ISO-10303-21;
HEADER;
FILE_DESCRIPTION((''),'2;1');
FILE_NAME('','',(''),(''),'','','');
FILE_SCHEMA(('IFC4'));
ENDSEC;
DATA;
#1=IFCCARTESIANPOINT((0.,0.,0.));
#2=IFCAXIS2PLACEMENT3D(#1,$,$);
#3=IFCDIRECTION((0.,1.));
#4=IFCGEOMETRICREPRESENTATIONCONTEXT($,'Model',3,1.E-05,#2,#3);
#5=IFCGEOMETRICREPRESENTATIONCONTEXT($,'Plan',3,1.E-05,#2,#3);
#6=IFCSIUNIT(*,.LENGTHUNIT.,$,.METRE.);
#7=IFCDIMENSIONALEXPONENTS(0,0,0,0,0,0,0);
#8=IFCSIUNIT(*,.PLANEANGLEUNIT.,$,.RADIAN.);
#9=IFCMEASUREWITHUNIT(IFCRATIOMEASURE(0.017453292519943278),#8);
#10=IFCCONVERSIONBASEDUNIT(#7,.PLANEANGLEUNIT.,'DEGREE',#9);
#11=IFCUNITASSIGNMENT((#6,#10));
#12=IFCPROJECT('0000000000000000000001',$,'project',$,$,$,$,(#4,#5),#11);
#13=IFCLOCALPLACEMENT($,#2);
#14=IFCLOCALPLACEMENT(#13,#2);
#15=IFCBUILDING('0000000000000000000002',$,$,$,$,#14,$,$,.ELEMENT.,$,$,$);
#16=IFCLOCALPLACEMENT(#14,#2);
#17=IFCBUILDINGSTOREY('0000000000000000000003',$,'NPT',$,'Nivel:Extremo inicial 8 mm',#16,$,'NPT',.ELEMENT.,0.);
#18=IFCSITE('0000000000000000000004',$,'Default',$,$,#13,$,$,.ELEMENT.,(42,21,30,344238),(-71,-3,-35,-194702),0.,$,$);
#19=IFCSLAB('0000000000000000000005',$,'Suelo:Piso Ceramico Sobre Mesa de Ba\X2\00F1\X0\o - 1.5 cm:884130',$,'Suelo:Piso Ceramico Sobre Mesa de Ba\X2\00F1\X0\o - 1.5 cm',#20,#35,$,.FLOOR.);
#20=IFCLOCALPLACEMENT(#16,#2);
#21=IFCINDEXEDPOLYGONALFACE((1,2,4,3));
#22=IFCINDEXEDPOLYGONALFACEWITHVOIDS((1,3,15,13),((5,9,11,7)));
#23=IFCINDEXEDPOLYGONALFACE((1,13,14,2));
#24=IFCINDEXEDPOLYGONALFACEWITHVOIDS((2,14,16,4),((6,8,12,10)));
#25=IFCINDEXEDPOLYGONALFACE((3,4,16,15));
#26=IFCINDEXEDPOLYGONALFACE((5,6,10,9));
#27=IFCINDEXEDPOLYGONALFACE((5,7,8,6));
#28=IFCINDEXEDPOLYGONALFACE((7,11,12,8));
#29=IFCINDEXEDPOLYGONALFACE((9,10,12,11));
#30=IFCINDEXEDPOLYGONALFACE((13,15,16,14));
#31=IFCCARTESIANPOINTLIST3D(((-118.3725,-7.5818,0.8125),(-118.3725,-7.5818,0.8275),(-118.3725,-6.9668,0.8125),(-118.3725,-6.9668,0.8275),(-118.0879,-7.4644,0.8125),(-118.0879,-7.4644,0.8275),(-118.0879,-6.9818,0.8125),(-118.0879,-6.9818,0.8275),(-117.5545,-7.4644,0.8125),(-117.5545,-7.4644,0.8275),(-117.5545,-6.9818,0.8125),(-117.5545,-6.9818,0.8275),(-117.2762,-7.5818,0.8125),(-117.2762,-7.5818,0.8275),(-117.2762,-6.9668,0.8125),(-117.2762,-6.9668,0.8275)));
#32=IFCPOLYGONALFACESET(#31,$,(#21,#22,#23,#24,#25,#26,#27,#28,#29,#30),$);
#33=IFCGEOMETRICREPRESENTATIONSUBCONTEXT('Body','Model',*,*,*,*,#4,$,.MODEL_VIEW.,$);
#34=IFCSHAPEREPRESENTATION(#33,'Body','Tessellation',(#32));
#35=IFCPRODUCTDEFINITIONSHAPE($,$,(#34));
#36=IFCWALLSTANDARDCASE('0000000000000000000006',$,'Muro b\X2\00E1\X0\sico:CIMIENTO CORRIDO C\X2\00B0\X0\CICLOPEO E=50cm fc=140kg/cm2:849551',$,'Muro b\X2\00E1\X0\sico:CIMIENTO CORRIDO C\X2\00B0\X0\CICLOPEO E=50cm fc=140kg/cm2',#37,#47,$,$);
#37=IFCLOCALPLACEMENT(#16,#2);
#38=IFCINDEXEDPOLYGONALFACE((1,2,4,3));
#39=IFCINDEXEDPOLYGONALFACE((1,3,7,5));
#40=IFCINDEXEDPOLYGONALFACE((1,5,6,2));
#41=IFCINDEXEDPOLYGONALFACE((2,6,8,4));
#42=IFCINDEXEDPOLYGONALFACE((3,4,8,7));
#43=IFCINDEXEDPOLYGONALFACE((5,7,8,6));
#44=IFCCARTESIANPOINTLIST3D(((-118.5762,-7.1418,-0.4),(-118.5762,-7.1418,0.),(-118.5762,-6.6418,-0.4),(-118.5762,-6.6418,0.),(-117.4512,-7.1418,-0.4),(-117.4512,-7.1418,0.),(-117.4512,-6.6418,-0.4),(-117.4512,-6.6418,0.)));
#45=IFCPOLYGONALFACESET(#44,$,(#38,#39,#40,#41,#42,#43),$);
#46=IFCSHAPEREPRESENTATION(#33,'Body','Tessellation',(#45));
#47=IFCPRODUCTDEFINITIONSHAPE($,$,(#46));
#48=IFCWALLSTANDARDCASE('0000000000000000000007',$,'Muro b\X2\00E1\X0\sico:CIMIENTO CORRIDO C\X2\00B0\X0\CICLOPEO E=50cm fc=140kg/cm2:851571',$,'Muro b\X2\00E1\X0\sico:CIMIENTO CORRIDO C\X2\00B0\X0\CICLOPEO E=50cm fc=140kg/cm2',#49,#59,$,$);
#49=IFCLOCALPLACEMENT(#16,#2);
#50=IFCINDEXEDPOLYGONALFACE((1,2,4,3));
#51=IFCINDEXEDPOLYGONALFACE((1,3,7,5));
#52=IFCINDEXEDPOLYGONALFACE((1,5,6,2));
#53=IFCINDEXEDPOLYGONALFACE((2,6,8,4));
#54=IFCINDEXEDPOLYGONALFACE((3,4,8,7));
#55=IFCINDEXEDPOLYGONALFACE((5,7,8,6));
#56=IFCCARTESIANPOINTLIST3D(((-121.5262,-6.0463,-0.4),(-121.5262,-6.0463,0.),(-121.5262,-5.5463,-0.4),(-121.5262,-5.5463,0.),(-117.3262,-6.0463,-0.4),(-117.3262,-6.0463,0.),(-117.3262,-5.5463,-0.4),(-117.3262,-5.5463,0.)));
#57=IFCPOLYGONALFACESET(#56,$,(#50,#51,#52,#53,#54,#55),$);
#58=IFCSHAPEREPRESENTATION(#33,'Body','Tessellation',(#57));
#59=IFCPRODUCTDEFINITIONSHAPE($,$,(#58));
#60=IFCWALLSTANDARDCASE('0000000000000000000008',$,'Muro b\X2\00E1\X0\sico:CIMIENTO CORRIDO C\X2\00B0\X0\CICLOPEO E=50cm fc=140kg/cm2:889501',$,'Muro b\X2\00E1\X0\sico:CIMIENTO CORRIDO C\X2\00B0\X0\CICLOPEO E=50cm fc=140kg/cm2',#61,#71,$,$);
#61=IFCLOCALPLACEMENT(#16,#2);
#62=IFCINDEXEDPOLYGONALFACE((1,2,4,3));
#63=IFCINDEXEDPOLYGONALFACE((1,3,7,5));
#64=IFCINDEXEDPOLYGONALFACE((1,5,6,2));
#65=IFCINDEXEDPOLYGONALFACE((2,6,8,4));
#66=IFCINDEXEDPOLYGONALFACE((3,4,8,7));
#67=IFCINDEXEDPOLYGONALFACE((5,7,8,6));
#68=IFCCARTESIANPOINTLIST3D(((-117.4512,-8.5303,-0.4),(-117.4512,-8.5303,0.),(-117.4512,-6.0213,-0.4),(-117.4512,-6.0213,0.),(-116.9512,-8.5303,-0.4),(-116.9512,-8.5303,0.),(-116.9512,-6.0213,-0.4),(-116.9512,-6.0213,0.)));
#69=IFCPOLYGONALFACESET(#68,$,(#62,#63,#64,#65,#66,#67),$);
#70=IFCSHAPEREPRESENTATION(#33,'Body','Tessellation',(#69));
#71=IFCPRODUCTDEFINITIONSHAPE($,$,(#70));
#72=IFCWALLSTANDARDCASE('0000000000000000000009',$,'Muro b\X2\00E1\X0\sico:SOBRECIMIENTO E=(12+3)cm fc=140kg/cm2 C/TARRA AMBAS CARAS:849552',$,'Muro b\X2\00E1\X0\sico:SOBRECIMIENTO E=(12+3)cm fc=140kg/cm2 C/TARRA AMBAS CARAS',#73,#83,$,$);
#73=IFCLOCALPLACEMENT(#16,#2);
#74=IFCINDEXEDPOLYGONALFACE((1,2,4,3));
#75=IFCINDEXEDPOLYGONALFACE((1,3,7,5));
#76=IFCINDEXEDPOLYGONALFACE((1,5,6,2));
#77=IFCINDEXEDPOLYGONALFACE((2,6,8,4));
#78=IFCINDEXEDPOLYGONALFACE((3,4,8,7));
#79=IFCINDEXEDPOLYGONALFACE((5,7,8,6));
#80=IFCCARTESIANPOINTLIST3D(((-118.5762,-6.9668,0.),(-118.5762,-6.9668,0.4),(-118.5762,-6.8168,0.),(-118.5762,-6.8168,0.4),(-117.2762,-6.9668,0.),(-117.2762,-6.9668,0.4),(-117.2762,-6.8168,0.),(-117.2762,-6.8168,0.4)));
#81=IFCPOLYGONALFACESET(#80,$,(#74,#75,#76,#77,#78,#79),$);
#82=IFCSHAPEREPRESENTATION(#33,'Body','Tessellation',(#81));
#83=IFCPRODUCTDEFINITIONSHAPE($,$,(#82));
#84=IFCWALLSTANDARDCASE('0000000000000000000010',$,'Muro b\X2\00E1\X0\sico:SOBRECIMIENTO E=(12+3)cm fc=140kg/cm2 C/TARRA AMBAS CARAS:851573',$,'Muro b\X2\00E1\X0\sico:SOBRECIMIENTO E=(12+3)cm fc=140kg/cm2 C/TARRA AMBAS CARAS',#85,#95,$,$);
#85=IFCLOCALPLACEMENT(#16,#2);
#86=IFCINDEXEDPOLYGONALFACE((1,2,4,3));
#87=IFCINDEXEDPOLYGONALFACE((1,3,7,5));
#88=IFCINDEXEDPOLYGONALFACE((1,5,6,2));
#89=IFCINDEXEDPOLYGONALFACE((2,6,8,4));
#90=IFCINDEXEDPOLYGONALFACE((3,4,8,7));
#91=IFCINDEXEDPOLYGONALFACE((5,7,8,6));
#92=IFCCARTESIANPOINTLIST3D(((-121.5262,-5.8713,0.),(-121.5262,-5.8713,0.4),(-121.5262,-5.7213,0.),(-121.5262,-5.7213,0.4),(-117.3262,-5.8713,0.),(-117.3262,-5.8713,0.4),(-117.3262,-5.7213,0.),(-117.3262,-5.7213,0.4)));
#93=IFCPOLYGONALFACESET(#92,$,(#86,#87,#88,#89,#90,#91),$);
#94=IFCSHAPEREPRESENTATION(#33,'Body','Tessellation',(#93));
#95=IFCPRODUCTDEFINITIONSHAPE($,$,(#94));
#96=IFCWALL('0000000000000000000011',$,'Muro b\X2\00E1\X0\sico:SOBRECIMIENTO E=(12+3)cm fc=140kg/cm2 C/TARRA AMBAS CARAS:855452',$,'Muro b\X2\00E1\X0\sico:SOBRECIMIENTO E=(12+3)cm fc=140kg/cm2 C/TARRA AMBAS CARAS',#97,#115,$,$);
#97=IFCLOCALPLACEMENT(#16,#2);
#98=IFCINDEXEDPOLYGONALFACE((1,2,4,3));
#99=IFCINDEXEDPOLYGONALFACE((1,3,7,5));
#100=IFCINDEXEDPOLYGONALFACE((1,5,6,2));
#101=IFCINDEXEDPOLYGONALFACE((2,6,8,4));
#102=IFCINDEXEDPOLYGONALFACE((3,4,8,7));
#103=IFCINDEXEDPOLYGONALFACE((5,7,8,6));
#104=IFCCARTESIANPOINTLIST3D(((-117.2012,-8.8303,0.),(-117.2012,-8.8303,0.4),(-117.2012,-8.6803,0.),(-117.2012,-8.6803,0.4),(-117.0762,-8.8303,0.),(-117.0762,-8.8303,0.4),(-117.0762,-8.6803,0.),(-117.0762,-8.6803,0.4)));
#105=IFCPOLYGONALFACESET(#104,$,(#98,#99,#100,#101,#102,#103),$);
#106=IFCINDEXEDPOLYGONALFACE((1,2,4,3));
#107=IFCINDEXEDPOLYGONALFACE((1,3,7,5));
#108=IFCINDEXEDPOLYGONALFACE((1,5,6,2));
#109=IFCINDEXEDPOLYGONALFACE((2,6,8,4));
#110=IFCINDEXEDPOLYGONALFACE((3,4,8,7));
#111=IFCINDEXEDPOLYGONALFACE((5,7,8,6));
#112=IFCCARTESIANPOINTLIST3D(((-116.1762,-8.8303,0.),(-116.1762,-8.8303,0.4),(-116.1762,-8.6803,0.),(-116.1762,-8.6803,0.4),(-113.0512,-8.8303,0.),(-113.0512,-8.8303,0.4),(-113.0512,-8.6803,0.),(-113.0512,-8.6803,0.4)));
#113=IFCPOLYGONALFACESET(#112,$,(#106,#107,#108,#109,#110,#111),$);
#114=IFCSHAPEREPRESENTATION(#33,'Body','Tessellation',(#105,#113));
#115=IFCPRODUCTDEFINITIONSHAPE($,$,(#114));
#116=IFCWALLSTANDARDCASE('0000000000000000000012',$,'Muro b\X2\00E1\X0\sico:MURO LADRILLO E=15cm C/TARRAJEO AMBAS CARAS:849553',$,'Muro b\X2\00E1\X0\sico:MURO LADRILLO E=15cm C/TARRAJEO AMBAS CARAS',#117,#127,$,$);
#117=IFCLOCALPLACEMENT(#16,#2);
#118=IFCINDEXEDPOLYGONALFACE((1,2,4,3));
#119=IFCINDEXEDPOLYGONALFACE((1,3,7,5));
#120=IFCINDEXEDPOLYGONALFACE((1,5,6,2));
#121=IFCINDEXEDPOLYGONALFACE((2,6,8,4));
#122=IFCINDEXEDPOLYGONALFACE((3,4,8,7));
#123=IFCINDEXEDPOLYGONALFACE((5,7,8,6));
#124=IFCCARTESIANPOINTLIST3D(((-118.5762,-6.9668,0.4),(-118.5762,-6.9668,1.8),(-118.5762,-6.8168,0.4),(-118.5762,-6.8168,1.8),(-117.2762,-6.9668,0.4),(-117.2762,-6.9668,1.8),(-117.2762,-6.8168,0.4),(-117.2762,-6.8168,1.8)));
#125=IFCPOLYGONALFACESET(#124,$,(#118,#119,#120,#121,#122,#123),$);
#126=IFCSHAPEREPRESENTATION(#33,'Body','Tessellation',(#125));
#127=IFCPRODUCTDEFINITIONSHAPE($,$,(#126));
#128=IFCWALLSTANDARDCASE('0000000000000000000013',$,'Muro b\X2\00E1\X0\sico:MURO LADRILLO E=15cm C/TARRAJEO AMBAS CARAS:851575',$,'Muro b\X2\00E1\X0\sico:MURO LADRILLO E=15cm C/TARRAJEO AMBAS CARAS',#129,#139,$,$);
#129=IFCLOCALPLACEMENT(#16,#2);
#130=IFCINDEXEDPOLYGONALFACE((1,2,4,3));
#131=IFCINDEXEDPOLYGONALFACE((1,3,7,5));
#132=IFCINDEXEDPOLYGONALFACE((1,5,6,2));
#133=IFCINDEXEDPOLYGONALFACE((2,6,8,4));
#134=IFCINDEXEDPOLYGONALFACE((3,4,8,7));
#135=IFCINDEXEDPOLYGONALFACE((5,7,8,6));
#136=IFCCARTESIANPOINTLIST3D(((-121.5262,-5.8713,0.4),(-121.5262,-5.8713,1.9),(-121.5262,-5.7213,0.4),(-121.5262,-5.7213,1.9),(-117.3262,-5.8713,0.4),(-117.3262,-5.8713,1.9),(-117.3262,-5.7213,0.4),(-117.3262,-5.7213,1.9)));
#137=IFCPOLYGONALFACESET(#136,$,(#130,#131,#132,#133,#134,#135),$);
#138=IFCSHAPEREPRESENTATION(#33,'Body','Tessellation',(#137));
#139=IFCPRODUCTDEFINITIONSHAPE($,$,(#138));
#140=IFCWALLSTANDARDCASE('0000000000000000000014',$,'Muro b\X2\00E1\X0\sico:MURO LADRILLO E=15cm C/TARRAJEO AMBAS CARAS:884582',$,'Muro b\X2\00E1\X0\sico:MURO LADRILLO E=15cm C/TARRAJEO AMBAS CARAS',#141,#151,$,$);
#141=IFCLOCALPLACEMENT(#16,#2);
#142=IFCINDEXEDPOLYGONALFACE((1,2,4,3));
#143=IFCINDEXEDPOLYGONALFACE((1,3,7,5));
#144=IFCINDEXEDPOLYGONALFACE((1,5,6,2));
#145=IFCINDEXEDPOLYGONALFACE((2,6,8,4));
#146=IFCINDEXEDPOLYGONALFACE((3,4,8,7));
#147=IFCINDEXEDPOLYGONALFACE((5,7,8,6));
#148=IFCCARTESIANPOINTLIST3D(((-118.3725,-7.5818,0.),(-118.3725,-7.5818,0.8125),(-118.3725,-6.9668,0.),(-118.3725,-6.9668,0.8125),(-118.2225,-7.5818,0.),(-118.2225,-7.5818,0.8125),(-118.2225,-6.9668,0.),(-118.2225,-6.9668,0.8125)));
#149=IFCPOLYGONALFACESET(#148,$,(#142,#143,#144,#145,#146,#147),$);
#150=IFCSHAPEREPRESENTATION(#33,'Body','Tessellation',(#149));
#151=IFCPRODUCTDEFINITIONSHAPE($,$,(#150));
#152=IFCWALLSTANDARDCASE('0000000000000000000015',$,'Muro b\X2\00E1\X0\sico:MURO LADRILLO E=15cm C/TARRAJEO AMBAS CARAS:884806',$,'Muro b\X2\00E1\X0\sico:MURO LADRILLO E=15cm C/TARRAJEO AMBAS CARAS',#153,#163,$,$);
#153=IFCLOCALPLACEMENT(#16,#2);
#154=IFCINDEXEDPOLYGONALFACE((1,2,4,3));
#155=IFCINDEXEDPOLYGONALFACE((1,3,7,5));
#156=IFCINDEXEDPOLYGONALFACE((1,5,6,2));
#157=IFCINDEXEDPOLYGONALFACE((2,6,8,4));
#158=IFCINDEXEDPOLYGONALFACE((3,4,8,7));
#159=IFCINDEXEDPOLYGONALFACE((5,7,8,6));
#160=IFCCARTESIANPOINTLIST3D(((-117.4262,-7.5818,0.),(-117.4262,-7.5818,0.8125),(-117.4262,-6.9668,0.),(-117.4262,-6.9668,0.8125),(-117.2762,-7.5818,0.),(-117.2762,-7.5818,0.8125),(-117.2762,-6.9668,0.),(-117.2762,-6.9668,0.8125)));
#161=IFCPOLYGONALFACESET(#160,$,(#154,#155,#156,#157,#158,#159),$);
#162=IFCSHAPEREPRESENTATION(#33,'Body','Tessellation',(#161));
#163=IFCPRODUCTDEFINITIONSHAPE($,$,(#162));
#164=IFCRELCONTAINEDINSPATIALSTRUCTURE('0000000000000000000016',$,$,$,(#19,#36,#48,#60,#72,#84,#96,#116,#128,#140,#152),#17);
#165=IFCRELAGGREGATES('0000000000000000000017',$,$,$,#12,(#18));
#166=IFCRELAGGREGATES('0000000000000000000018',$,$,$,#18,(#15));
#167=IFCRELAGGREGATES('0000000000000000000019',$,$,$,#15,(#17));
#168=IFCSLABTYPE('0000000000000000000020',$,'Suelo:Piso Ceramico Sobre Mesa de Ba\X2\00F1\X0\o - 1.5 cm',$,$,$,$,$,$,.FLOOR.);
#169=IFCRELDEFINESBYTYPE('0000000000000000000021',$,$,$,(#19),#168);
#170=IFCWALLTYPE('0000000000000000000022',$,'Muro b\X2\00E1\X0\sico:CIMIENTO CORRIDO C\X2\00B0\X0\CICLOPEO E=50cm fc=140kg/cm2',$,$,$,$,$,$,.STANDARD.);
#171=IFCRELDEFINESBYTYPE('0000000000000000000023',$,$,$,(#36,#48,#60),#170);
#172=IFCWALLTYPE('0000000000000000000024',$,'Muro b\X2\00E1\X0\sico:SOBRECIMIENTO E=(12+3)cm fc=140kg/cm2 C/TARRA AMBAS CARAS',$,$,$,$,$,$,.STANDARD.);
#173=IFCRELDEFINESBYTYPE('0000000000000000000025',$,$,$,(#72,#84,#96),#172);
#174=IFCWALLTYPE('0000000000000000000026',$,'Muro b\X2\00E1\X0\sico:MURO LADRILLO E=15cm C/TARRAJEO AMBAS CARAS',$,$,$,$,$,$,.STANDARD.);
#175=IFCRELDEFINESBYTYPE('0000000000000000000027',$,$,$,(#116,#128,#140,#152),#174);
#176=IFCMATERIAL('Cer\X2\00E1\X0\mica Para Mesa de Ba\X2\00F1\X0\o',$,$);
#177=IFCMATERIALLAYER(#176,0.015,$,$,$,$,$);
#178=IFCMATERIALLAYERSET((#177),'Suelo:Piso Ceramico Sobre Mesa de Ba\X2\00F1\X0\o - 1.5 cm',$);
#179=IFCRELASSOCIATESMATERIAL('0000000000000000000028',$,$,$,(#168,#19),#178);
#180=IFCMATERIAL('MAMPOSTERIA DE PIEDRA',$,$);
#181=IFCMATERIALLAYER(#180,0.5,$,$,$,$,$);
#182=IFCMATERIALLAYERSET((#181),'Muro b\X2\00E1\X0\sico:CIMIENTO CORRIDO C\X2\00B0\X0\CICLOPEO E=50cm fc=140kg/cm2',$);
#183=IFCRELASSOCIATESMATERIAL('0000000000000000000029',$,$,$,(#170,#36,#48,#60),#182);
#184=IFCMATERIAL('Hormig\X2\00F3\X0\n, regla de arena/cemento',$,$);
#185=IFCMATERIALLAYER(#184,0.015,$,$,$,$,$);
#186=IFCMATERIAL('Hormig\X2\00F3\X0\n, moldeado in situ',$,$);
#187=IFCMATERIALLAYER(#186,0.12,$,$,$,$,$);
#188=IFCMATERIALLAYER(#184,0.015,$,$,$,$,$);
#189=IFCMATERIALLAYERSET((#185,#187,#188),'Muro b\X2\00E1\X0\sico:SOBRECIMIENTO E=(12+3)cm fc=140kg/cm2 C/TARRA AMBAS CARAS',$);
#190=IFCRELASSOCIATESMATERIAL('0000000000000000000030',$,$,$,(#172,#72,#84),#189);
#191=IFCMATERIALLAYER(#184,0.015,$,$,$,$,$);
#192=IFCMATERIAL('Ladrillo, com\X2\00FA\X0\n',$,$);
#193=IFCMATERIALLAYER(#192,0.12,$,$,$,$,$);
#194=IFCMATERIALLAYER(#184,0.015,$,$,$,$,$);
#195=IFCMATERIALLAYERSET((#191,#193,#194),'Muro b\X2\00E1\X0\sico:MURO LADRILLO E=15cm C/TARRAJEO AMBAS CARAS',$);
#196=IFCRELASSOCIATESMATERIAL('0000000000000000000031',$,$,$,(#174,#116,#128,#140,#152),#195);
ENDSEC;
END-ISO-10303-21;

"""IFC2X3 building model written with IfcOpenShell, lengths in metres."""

from ifc_helpers import new_model, entity, si_unit, converted_unit, direction, frame, frame_2d, origin, origin_2d_with_axis, place, context, subcontext, project, spatial, rectangle, extrude, material, layer, layer_set, layer_usage, type_object, element, save


model = new_model("IFC2X3")

# Units and contexts
model_context = context("Model", 3, precision=1e-05, world=origin(), true_north=direction((0.0, 1.0)))
plan_context = context("Plan", 3, precision=1e-05, world=origin(), true_north=direction((0.0, 1.0)))
body_context = subcontext(model_context, "Body", "Model", "MODEL_VIEW")
ifc_project = project(units=[si_unit("LENGTHUNIT", "METRE"), converted_unit("PLANEANGLEUNIT", "DEGREE", entity("IfcRatioMeasure", 0.017453292519943278), si_unit("PLANEANGLEUNIT", "RADIAN"), dimensions=[0, 0, 0, 0, 0, 0, 0])], contexts=[model_context, plan_context])

# Site, building, storey
site_placement = place(None, origin())
site = spatial("IfcSite", under=ifc_project, at=site_placement, Name="Default", CompositionType="ELEMENT", RefLatitude=(42, 21, 30, 344238), RefLongitude=(-71, -3, -35, -194702), RefElevation=0.0)
building_placement = place(site_placement, origin())
building = spatial("IfcBuilding", under=site, at=building_placement, CompositionType="ELEMENT")
storey_placement = place(building_placement, origin())
storey = spatial("IfcBuildingStorey", under=building, at=storey_placement, Name="NPT", ObjectType="Nivel:Extremo inicial 8 mm", LongName="NPT", CompositionType="ELEMENT", Elevation=0.0)

# Slab, opening
ifc_material_1 = material(Name="Cerámica Para Mesa de Baño")
ifc_layer_1 = layer(ifc_material_1, 0.015)
ifc_layer_set_1 = layer_set([ifc_layer_1], Name="Suelo:Piso Ceramico Sobre Mesa de Baño - 1.5 cm")
ifc_layer_usage_1 = layer_usage(ifc_layer_set_1, "AXIS3", "POSITIVE", 0.0)
slab_type = type_object("IfcSlabType", Name="Suelo:Piso Ceramico Sobre Mesa de Baño - 1.5 cm", PredefinedType="FLOOR", material=ifc_layer_set_1)
slab_placement = place(storey_placement, frame((-118.3725, -7.5818, 0.8125)))
slab = element("IfcSlab", 1, at=slab_placement, inside=storey, type_object=slab_type, material=ifc_layer_usage_1, Name="Suelo:Piso Ceramico Sobre Mesa de Baño - 1.5 cm:884130", ObjectType="Suelo:Piso Ceramico Sobre Mesa de Baño - 1.5 cm", PredefinedType="FLOOR", context=body_context, shape_type="SweptSolid", body=[
    extrude(rectangle(XDim=0.615, YDim=1.0962, at=frame_2d((0.0, 0.0), x_axis=(0.0, 1.0))), frame((0.5481, 0.3075, 0.015), z_axis=(0.0, 0.0, -1.0), x_axis=(-1.0, 0.0, 0.0)), (0.0, 0.0, 1.0), 0.015),
])
opening_placement = place(slab_placement, frame((0.5513, 0.3587, 0.015)))
element("IfcOpeningElement", 2, at=opening_placement, cuts=slab, ObjectType="Opening", context=body_context, shape_type="SweptSolid", body=[
    extrude(rectangle(XDim=0.5334, YDim=0.4826, at=origin_2d_with_axis()), frame((0.0, 0.0, 0.0), z_axis=(0.0, 0.0, -1.0), x_axis=(-1.0, 0.0, 0.0)), (0.0, 0.0, 1.0), 0.015),
])

# Walls
ifc_material_2 = material(Name="MAMPOSTERIA DE PIEDRA")
ifc_layer_2 = layer(ifc_material_2, 0.5)
ifc_layer_set_2 = layer_set([ifc_layer_2], Name="Muro básico:CIMIENTO CORRIDO C°CICLOPEO E=50cm fc=140kg/cm2")
ifc_layer_usage_2 = layer_usage(ifc_layer_set_2, "AXIS2", "POSITIVE", -0.25)
wall_type_1 = type_object("IfcWallType", Name="Muro básico:CIMIENTO CORRIDO C°CICLOPEO E=50cm fc=140kg/cm2", PredefinedType="STANDARD", material=ifc_layer_set_2)
wall_1_placement = place(storey_placement, frame((-118.5762, -6.8918, -0.4)))
element("IfcWallStandardCase", 3, at=wall_1_placement, inside=storey, type_object=wall_type_1, material=ifc_layer_usage_2, Name="Muro básico:CIMIENTO CORRIDO C°CICLOPEO E=50cm fc=140kg/cm2:849551", ObjectType="Muro básico:CIMIENTO CORRIDO C°CICLOPEO E=50cm fc=140kg/cm2", context=body_context, shape_type="SweptSolid", body=[
    extrude(rectangle(XDim=1.125, YDim=0.5, at=frame_2d((0.5625, 0.0), x_axis=(-1.0, 0.0))), origin(), (0.0, 0.0, 1.0), 0.4),
])
ifc_layer_usage_3 = layer_usage(ifc_layer_set_2, "AXIS2", "POSITIVE", -0.25)
wall_2_placement = place(storey_placement, frame((-117.3262, -5.7963, -0.4), z_axis=(0.0, 0.0, 1.0), x_axis=(-1.0, 0.0, 0.0)))
element("IfcWallStandardCase", 4, at=wall_2_placement, inside=storey, type_object=wall_type_1, material=ifc_layer_usage_3, Name="Muro básico:CIMIENTO CORRIDO C°CICLOPEO E=50cm fc=140kg/cm2:851571", ObjectType="Muro básico:CIMIENTO CORRIDO C°CICLOPEO E=50cm fc=140kg/cm2", context=body_context, shape_type="SweptSolid", body=[
    extrude(rectangle(XDim=4.2, YDim=0.5, at=frame_2d((2.1, 0.0), x_axis=(-1.0, 0.0))), origin(), (0.0, 0.0, 1.0), 0.4),
])
ifc_layer_usage_4 = layer_usage(ifc_layer_set_2, "AXIS2", "NEGATIVE", 0.25)
wall_3_placement = place(storey_placement, frame((-117.2012, -8.5303, -0.4), z_axis=(0.0, 0.0, 1.0), x_axis=(0.0, 1.0, 0.0)))
element("IfcWallStandardCase", 5, at=wall_3_placement, inside=storey, type_object=wall_type_1, material=ifc_layer_usage_4, Name="Muro básico:CIMIENTO CORRIDO C°CICLOPEO E=50cm fc=140kg/cm2:889501", ObjectType="Muro básico:CIMIENTO CORRIDO C°CICLOPEO E=50cm fc=140kg/cm2", context=body_context, shape_type="SweptSolid", body=[
    extrude(rectangle(XDim=2.5091, YDim=0.5, at=frame_2d((1.2545, 0.0), x_axis=(-1.0, 0.0))), origin(), (0.0, 0.0, 1.0), 0.4),
])
ifc_material_3 = material(Name="Hormigón, regla de arena/cemento")
ifc_layer_3 = layer(ifc_material_3, 0.015)
ifc_material_4 = material(Name="Hormigón, moldeado in situ")
ifc_layer_4 = layer(ifc_material_4, 0.12)
ifc_layer_5 = layer(ifc_material_3, 0.015)
ifc_layer_set_3 = layer_set([ifc_layer_3, ifc_layer_4, ifc_layer_5], Name="Muro básico:SOBRECIMIENTO E=(12+3)cm fc=140kg/cm2 C/TARRA AMBAS CARAS")
ifc_layer_usage_5 = layer_usage(ifc_layer_set_3, "AXIS2", "POSITIVE", -0.075)
wall_type_2 = type_object("IfcWallType", Name="Muro básico:SOBRECIMIENTO E=(12+3)cm fc=140kg/cm2 C/TARRA AMBAS CARAS", PredefinedType="STANDARD", material=ifc_layer_set_3)
wall_4_placement = place(storey_placement, frame((-118.5762, -6.8918, 0.0)))
element("IfcWallStandardCase", 6, at=wall_4_placement, inside=storey, type_object=wall_type_2, material=ifc_layer_usage_5, Name="Muro básico:SOBRECIMIENTO E=(12+3)cm fc=140kg/cm2 C/TARRA AMBAS CARAS:849552", ObjectType="Muro básico:SOBRECIMIENTO E=(12+3)cm fc=140kg/cm2 C/TARRA AMBAS CARAS", context=body_context, shape_type="SweptSolid", body=[
    extrude(rectangle(XDim=1.3, YDim=0.15, at=frame_2d((0.65, 0.0), x_axis=(-1.0, 0.0))), origin(), (0.0, 0.0, 1.0), 0.4),
])
ifc_layer_usage_6 = layer_usage(ifc_layer_set_3, "AXIS2", "POSITIVE", -0.075)
wall_5_placement = place(storey_placement, frame((-117.3262, -5.7963, 0.0), z_axis=(0.0, 0.0, 1.0), x_axis=(-1.0, 0.0, 0.0)))
element("IfcWallStandardCase", 7, at=wall_5_placement, inside=storey, type_object=wall_type_2, material=ifc_layer_usage_6, Name="Muro básico:SOBRECIMIENTO E=(12+3)cm fc=140kg/cm2 C/TARRA AMBAS CARAS:851573", ObjectType="Muro básico:SOBRECIMIENTO E=(12+3)cm fc=140kg/cm2 C/TARRA AMBAS CARAS", context=body_context, shape_type="SweptSolid", body=[
    extrude(rectangle(XDim=4.2, YDim=0.15, at=frame_2d((2.1, 0.0), x_axis=(-1.0, 0.0))), origin(), (0.0, 0.0, 1.0), 0.4),
])
wall_6_placement = place(storey_placement, frame((-117.2012, -8.7553, 0.0)))
element("IfcWall", 8, at=wall_6_placement, inside=storey, type_object=wall_type_2, Name="Muro básico:SOBRECIMIENTO E=(12+3)cm fc=140kg/cm2 C/TARRA AMBAS CARAS:855452", ObjectType="Muro básico:SOBRECIMIENTO E=(12+3)cm fc=140kg/cm2 C/TARRA AMBAS CARAS", context=body_context, shape_type="SweptSolid", body=[
    extrude(rectangle(XDim=0.125, YDim=0.15, at=frame_2d((0.0, 0.0), x_axis=(1.0, 0.0))), frame((0.0625, 0.0, 0.0)), (0.0, 0.0, 1.0), 0.4),
    extrude(rectangle(XDim=3.125, YDim=0.15, at=frame_2d((0.0, 0.0), x_axis=(1.0, 0.0))), frame((2.5875, 0.0, 0.0), z_axis=(0.0, 0.0, 1.0), x_axis=(-1.0, 0.0, 0.0)), (0.0, 0.0, 1.0), 0.4),
])
ifc_layer_6 = layer(ifc_material_3, 0.015)
ifc_material_5 = material(Name="Ladrillo, común")
ifc_layer_7 = layer(ifc_material_5, 0.12)
ifc_layer_8 = layer(ifc_material_3, 0.015)
ifc_layer_set_4 = layer_set([ifc_layer_6, ifc_layer_7, ifc_layer_8], Name="Muro básico:MURO LADRILLO E=15cm C/TARRAJEO AMBAS CARAS")
ifc_layer_usage_7 = layer_usage(ifc_layer_set_4, "AXIS2", "POSITIVE", -0.075)
wall_type_3 = type_object("IfcWallType", Name="Muro básico:MURO LADRILLO E=15cm C/TARRAJEO AMBAS CARAS", PredefinedType="STANDARD", material=ifc_layer_set_4)
wall_7_placement = place(storey_placement, frame((-118.5762, -6.8918, 0.4)))
element("IfcWallStandardCase", 9, at=wall_7_placement, inside=storey, type_object=wall_type_3, material=ifc_layer_usage_7, Name="Muro básico:MURO LADRILLO E=15cm C/TARRAJEO AMBAS CARAS:849553", ObjectType="Muro básico:MURO LADRILLO E=15cm C/TARRAJEO AMBAS CARAS", context=body_context, shape_type="SweptSolid", body=[
    extrude(rectangle(XDim=1.3, YDim=0.15, at=frame_2d((0.65, 0.0), x_axis=(-1.0, 0.0))), origin(), (0.0, 0.0, 1.0), 1.4),
])
ifc_layer_usage_8 = layer_usage(ifc_layer_set_4, "AXIS2", "POSITIVE", -0.075)
wall_8_placement = place(storey_placement, frame((-117.3262, -5.7963, 0.4), z_axis=(0.0, 0.0, 1.0), x_axis=(-1.0, 0.0, 0.0)))
element("IfcWallStandardCase", 10, at=wall_8_placement, inside=storey, type_object=wall_type_3, material=ifc_layer_usage_8, Name="Muro básico:MURO LADRILLO E=15cm C/TARRAJEO AMBAS CARAS:851575", ObjectType="Muro básico:MURO LADRILLO E=15cm C/TARRAJEO AMBAS CARAS", context=body_context, shape_type="SweptSolid", body=[
    extrude(rectangle(XDim=4.2, YDim=0.15, at=frame_2d((2.1, 0.0), x_axis=(-1.0, 0.0))), origin(), (0.0, 0.0, 1.0), 1.5),
])
ifc_layer_usage_9 = layer_usage(ifc_layer_set_4, "AXIS2", "NEGATIVE", 0.075)
wall_9_placement = place(storey_placement, frame((-118.2975, -7.5818, 0.0), z_axis=(0.0, 0.0, 1.0), x_axis=(0.0, 1.0, 0.0)))
element("IfcWallStandardCase", 11, at=wall_9_placement, inside=storey, type_object=wall_type_3, material=ifc_layer_usage_9, Name="Muro básico:MURO LADRILLO E=15cm C/TARRAJEO AMBAS CARAS:884582", ObjectType="Muro básico:MURO LADRILLO E=15cm C/TARRAJEO AMBAS CARAS", context=body_context, shape_type="SweptSolid", body=[
    extrude(rectangle(XDim=0.615, YDim=0.15, at=frame_2d((0.3075, 0.0), x_axis=(-1.0, 0.0))), origin(), (0.0, 0.0, 1.0), 0.8125),
])
ifc_layer_usage_10 = layer_usage(ifc_layer_set_4, "AXIS2", "NEGATIVE", 0.075)
wall_10_placement = place(storey_placement, frame((-117.3512, -7.5818, 0.0), z_axis=(0.0, 0.0, 1.0), x_axis=(0.0, 1.0, 0.0)))
element("IfcWallStandardCase", 12, at=wall_10_placement, inside=storey, type_object=wall_type_3, material=ifc_layer_usage_10, Name="Muro básico:MURO LADRILLO E=15cm C/TARRAJEO AMBAS CARAS:884806", ObjectType="Muro básico:MURO LADRILLO E=15cm C/TARRAJEO AMBAS CARAS", context=body_context, shape_type="SweptSolid", body=[
    extrude(rectangle(XDim=0.615, YDim=0.15, at=frame_2d((0.3075, 0.0), x_axis=(-1.0, 0.0))), origin(), (0.0, 0.0, 1.0), 0.8125),
])

save(model, "model.ifc")
